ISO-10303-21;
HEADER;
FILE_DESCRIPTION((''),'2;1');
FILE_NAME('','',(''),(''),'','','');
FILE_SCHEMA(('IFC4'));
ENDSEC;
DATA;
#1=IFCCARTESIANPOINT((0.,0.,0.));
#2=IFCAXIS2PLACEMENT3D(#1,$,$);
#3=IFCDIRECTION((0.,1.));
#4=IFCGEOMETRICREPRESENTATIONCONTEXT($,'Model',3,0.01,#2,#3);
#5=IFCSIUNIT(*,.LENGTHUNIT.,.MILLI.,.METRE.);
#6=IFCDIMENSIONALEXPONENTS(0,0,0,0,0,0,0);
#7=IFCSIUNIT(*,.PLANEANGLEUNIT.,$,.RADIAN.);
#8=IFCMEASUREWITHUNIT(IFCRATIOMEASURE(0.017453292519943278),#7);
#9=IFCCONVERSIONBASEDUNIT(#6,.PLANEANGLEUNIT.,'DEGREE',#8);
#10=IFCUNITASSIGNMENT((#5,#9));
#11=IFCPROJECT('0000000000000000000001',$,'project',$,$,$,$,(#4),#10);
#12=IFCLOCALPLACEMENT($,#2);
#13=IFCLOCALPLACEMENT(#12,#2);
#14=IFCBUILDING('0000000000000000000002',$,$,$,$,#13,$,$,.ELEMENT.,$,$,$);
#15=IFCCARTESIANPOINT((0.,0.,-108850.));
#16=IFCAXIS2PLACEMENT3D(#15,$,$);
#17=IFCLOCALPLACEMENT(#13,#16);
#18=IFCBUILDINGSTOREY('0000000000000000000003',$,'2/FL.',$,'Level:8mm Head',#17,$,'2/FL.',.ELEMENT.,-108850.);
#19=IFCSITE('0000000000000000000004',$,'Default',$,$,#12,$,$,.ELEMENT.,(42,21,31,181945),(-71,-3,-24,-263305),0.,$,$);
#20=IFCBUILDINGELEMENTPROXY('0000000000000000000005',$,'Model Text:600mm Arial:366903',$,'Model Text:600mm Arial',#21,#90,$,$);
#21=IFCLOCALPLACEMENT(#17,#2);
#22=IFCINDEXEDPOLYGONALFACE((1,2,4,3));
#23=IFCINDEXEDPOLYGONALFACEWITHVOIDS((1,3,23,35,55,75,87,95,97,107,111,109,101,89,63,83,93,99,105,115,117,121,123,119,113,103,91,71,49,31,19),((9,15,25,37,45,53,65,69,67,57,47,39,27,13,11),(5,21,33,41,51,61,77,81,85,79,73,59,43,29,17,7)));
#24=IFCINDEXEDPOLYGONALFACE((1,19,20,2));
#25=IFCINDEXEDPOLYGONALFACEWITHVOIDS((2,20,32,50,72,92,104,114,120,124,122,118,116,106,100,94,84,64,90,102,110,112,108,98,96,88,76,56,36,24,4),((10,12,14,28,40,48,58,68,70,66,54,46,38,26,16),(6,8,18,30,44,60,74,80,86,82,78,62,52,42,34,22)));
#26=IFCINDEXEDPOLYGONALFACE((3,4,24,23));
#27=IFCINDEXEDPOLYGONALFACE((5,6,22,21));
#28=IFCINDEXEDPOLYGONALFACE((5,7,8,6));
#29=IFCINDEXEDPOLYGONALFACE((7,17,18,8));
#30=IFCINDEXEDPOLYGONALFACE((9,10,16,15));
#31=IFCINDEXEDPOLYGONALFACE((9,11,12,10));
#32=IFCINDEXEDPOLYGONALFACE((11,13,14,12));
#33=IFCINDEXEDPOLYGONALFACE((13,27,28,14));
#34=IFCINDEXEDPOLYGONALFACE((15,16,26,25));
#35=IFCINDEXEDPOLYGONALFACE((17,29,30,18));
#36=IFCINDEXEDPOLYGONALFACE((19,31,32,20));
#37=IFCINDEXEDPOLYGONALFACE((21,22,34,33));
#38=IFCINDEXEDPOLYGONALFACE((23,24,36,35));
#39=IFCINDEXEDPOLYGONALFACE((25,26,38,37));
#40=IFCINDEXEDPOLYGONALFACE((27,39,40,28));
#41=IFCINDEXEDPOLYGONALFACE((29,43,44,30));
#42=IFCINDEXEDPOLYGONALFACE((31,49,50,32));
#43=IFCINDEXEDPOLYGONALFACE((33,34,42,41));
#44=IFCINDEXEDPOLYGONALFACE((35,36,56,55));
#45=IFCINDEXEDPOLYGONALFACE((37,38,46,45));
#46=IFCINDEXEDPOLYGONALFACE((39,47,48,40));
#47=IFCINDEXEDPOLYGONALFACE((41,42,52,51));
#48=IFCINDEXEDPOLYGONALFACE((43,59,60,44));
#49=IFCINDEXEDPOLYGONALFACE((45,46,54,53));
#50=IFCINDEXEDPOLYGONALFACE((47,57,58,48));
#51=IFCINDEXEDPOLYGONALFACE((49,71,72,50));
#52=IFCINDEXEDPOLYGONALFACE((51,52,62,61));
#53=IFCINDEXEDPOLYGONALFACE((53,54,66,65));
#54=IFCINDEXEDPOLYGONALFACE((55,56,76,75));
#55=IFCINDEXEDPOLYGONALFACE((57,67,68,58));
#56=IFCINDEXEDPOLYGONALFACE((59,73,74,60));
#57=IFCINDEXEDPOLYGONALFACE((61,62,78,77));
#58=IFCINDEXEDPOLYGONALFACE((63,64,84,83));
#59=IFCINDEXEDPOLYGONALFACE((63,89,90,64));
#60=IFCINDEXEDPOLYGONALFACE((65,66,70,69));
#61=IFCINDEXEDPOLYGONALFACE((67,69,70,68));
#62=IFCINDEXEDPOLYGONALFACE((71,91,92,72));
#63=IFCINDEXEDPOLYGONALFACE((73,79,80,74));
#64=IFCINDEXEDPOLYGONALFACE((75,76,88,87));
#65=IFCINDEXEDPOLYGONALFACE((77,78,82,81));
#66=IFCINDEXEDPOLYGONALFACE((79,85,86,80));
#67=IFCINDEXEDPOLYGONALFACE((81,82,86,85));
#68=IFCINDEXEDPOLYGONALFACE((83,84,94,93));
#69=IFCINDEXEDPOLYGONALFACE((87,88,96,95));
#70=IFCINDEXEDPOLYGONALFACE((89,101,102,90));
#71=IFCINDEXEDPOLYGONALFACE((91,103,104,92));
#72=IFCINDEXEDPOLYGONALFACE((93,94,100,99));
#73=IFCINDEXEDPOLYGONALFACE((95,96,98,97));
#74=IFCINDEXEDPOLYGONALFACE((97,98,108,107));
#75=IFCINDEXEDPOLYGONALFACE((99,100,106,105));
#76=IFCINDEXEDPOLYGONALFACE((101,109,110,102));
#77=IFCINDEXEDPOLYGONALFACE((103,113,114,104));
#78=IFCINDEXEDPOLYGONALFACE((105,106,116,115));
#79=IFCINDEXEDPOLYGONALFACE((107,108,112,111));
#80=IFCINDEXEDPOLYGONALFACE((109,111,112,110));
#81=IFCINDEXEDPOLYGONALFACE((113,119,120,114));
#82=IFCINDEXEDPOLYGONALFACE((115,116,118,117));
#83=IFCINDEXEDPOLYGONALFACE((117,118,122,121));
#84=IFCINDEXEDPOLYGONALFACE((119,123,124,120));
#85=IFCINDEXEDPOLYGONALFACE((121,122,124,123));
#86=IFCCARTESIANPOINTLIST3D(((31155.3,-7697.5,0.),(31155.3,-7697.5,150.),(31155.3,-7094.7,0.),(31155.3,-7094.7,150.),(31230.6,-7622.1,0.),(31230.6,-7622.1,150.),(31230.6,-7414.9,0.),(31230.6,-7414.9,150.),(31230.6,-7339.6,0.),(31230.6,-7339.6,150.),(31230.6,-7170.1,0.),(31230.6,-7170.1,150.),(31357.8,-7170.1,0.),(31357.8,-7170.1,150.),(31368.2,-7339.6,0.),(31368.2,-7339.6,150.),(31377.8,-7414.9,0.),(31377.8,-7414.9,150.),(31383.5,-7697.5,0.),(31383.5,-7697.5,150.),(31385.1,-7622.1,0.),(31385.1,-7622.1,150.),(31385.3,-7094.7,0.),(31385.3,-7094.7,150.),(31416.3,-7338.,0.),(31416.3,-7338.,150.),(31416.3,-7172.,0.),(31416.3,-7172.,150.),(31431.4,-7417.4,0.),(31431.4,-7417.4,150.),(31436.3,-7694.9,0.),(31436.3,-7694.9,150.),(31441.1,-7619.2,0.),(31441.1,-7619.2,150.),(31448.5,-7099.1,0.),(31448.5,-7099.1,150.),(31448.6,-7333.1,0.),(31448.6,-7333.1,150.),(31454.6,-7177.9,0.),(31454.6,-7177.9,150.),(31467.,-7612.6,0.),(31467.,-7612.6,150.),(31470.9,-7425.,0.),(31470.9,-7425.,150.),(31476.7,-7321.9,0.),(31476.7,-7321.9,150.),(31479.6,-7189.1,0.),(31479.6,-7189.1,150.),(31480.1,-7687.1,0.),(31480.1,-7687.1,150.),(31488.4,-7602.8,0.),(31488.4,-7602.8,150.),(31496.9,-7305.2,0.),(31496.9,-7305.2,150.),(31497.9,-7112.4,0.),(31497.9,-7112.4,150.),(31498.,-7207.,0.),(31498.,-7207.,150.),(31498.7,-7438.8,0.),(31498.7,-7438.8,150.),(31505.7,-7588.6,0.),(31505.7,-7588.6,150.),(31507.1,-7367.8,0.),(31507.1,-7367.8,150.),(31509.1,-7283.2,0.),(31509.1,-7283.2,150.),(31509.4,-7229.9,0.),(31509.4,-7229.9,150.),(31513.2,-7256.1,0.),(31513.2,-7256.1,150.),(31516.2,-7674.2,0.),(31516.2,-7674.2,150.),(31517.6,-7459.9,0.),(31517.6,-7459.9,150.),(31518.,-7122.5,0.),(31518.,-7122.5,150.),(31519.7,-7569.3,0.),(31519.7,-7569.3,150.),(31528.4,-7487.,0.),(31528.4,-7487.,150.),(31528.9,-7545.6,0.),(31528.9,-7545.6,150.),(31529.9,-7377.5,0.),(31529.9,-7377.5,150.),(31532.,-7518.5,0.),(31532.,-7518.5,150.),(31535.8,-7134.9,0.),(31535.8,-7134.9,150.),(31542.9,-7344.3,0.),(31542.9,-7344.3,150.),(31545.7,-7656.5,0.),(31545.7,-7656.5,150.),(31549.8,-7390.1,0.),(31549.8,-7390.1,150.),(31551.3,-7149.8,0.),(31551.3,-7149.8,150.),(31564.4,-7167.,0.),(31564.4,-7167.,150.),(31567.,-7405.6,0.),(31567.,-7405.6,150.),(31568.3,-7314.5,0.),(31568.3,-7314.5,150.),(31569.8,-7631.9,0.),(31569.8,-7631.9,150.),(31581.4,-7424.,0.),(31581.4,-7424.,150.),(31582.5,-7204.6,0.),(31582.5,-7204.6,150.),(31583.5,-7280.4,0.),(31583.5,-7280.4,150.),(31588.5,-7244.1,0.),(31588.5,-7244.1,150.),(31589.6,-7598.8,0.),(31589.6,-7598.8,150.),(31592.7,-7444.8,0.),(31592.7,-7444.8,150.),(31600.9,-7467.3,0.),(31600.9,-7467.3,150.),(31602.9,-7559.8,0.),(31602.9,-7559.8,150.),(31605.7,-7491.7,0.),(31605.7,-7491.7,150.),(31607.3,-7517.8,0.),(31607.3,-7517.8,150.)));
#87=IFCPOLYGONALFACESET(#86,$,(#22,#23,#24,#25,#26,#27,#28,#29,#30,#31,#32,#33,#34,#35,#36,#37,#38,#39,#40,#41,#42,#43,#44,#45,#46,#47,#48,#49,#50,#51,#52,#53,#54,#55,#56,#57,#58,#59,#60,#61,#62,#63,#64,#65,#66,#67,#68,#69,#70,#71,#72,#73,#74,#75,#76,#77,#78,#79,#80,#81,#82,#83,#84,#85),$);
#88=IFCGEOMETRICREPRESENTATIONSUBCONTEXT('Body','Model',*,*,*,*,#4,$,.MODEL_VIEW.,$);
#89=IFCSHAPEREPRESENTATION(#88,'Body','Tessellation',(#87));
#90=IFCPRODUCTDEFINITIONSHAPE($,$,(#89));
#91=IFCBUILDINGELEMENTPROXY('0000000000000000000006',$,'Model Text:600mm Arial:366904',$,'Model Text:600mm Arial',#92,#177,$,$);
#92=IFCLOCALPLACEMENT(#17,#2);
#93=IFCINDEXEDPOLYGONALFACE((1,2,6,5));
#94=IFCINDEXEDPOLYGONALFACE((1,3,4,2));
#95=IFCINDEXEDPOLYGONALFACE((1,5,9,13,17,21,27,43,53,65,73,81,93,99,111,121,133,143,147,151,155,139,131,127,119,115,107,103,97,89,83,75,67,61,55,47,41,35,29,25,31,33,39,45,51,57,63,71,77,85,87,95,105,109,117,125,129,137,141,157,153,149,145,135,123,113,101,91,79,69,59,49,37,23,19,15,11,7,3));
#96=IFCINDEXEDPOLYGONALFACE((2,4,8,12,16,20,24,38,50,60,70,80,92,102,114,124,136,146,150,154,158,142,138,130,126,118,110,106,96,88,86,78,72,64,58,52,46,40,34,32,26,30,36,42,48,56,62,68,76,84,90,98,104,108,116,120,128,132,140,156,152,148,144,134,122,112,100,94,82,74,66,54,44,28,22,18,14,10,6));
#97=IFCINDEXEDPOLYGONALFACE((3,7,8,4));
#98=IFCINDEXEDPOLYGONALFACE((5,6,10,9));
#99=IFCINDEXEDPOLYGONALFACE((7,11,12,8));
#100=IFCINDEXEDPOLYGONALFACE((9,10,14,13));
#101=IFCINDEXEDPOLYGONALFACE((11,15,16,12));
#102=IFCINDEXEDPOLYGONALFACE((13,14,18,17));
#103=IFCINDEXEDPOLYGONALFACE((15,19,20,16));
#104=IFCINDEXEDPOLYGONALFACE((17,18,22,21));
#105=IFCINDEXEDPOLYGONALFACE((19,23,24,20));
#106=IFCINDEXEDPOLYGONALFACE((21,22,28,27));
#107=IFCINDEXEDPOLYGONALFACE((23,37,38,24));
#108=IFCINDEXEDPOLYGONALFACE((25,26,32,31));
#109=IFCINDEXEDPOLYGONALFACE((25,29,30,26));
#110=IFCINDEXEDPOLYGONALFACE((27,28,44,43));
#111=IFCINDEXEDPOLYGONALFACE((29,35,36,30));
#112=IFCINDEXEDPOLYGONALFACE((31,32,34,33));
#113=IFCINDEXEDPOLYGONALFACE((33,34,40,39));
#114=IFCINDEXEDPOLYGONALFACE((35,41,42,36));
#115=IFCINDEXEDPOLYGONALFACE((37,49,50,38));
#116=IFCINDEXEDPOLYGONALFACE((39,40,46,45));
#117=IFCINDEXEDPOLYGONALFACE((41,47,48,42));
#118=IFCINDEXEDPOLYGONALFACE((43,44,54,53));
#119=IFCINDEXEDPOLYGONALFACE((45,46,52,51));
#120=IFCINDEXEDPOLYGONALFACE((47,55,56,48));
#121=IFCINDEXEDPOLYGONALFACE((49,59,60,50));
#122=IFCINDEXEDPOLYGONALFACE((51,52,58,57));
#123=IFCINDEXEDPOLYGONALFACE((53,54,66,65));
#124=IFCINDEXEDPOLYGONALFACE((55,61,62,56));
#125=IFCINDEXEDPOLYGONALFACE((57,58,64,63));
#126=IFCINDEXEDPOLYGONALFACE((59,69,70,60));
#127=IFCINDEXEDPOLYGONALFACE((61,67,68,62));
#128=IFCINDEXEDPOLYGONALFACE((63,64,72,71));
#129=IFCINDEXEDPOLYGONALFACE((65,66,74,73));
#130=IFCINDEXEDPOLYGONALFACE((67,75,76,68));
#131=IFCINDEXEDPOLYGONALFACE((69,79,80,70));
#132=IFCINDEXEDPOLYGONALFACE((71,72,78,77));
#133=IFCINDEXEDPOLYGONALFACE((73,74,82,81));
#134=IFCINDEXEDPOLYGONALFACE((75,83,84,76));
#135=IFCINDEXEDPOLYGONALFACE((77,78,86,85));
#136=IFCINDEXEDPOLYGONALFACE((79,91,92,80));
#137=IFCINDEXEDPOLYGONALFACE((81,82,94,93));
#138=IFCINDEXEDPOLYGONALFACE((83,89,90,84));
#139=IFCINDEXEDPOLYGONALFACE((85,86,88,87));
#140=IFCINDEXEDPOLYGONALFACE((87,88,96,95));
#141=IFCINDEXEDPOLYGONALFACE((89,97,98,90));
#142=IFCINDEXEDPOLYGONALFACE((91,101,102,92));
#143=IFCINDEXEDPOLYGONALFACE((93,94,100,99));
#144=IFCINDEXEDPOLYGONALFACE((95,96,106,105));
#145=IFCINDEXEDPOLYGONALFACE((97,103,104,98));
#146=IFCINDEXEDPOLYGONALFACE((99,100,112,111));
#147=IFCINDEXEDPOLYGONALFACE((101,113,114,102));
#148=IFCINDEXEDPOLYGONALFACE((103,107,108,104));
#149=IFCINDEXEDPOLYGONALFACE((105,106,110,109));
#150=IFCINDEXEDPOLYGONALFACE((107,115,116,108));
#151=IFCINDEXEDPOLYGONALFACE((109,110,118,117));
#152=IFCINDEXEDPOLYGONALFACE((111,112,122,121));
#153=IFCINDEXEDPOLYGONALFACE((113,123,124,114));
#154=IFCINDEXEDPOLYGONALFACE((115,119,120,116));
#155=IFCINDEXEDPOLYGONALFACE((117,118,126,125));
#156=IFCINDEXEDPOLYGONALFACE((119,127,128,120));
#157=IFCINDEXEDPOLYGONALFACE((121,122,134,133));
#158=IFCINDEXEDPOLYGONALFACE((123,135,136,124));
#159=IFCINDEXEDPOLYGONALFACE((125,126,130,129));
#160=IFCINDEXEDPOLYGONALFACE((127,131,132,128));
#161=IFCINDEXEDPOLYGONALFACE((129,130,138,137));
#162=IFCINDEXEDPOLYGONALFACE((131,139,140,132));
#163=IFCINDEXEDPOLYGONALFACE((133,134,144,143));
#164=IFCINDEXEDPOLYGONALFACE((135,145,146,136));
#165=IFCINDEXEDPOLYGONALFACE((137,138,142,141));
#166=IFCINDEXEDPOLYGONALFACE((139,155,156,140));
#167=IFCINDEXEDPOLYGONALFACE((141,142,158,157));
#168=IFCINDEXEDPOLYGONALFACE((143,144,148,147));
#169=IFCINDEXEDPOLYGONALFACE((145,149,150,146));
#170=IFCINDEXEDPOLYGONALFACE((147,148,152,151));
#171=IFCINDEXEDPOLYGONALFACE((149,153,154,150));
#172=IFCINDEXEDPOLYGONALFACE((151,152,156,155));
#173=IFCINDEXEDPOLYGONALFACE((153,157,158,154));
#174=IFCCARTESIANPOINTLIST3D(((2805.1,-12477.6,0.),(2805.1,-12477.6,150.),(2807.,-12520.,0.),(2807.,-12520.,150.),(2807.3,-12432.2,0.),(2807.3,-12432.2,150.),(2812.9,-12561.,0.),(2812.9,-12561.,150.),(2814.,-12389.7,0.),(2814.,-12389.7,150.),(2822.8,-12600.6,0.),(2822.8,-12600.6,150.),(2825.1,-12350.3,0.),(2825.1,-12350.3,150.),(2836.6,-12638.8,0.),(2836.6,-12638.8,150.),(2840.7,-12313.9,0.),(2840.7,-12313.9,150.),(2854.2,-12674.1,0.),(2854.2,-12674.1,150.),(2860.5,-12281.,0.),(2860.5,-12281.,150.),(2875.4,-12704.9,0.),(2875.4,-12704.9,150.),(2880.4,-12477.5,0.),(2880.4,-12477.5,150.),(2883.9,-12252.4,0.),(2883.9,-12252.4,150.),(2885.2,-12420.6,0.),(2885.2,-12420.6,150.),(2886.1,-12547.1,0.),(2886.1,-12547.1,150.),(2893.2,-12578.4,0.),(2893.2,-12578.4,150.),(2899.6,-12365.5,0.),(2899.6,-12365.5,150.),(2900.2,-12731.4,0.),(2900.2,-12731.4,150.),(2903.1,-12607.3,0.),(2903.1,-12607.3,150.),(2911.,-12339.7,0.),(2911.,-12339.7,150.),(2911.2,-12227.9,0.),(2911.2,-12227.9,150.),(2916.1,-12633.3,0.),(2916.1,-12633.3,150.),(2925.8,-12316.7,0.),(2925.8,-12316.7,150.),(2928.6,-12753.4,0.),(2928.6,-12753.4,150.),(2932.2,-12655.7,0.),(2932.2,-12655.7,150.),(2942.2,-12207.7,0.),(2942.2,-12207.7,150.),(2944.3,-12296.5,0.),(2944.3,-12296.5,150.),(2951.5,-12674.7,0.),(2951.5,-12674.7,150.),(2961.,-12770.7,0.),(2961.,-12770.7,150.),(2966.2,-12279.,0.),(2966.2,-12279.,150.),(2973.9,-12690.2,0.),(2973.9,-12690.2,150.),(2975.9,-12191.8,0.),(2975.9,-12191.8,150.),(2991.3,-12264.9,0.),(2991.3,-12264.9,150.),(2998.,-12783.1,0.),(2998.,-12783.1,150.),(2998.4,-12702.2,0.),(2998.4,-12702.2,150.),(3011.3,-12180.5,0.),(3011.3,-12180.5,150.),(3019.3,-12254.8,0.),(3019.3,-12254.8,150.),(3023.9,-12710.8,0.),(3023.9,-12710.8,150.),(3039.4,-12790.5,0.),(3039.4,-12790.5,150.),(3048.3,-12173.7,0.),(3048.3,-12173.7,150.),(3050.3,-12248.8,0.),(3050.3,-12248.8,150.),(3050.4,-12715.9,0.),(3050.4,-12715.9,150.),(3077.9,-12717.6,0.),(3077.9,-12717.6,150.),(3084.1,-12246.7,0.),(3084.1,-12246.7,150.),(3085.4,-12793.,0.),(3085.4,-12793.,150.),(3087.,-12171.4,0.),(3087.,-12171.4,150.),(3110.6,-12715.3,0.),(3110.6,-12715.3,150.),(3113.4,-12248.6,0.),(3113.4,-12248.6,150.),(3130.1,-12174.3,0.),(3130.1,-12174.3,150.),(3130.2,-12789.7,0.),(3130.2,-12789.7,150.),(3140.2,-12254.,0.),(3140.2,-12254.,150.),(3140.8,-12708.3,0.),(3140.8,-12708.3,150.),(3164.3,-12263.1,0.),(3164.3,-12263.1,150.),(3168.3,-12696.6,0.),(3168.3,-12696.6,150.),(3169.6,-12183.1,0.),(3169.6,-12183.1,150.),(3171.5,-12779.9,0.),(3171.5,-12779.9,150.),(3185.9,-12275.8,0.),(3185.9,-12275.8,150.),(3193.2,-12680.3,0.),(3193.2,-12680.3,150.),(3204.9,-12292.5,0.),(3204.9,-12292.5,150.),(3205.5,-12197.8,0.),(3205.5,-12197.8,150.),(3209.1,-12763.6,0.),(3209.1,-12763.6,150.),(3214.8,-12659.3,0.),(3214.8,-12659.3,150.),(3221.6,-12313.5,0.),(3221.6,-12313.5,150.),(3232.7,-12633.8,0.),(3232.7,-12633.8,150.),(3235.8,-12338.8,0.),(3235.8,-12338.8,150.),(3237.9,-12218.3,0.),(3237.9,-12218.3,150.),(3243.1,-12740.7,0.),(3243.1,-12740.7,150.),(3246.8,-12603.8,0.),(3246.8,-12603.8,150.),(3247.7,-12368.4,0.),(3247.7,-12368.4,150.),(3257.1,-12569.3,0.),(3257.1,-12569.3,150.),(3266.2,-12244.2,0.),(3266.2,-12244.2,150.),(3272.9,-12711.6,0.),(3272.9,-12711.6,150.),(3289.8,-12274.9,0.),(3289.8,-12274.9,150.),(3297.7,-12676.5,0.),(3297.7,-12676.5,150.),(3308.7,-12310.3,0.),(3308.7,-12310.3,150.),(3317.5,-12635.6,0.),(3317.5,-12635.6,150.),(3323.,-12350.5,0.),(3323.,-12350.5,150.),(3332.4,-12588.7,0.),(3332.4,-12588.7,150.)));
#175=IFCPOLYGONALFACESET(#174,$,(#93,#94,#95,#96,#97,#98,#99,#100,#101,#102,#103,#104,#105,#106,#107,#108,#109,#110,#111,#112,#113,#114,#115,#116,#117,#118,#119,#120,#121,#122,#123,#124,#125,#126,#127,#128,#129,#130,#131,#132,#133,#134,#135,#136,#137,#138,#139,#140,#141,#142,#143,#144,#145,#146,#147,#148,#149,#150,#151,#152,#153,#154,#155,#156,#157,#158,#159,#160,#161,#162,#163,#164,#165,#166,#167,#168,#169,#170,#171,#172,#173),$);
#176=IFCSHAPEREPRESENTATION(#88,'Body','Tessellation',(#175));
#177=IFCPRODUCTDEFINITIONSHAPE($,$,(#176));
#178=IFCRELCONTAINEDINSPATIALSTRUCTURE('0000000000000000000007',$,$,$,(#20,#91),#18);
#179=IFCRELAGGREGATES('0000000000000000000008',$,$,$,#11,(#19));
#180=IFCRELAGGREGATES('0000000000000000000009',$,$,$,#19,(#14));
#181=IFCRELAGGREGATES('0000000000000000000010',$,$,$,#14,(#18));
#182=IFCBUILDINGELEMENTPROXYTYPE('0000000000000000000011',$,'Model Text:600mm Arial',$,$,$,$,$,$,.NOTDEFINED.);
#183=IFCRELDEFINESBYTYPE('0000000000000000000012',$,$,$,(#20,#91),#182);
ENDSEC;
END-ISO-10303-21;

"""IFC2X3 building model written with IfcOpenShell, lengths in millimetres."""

from ifc_helpers import new_model, entity, si_unit, converted_unit, direction, frame, origin, place, context, subcontext, project, spatial, polyline, outline, extrude, type_object, element, save


model = new_model("IFC2X3")

# Units and contexts
model_context = context("Model", 3, precision=0.01, world=origin(), true_north=direction((0.0, 1.0)))
body_context = subcontext(model_context, "Body", "Model", "MODEL_VIEW")
ifc_project = project(units=[si_unit("LENGTHUNIT", "METRE", prefix="MILLI"), converted_unit("PLANEANGLEUNIT", "DEGREE", entity("IfcRatioMeasure", 0.017453292519943278), si_unit("PLANEANGLEUNIT", "RADIAN"), dimensions=[0, 0, 0, 0, 0, 0, 0])], contexts=[model_context])

# Site, building, storey
site_placement = place(None, origin())
site = spatial("IfcSite", under=ifc_project, at=site_placement, Name="Default", CompositionType="ELEMENT", RefLatitude=(42, 21, 31, 181945), RefLongitude=(-71, -3, -24, -263305), RefElevation=0.0)
building_placement = place(site_placement, origin())
building = spatial("IfcBuilding", under=site, at=building_placement, CompositionType="ELEMENT")
storey_placement = place(building_placement, frame((0.0, 0.0, -108850.0)))
storey = spatial("IfcBuildingStorey", under=building, at=storey_placement, Name="2/FL.", ObjectType="Level:8mm Head", LongName="2/FL.", CompositionType="ELEMENT", Elevation=-108850.0)

# Building element proxies
building_element_proxy_type = type_object("IfcBuildingElementProxyType", Name="Model Text:600mm Arial", PredefinedType="NOTDEFINED")
proxy_1_placement = place(storey_placement, origin())
element("IfcBuildingElementProxy", 1, at=proxy_1_placement, inside=storey, type_object=building_element_proxy_type, Name="Model Text:600mm Arial:366903", ObjectType="Model Text:600mm Arial", context=body_context, shape_type="SweptSolid", body=[
    extrude(outline(polyline([(-359.0, -305.6), (-130.8, -305.6), (-78.0, -303.0), (-34.2, -295.2), (1.9, -282.4), (31.4, -264.6), (55.5, -240.1), (75.3, -206.9), (88.6, -167.9), (93.0, -125.9), (91.4, -99.8), (86.5, -75.5), (78.4, -52.9), (67.1, -32.2), (52.7, -13.8), (35.5, 1.7), (15.6, 14.3), (-7.2, 24.0), (28.6, 47.5), (54.0, 77.4), (69.1, 111.5), (74.2, 147.8), (68.2, 187.2), (50.1, 224.9), (37.0, 242.1), (21.5, 256.9), (3.7, 269.4), (-16.4, 279.4), (-65.8, 292.7), (-129.0, 297.2), (-359.0, 297.2), (-359.0, -305.6)]), holes=[polyline([(-283.7, 52.3), (-283.7, 221.8), (-156.5, 221.8), (-98.0, 219.8), (-59.7, 213.9), (-34.7, 202.7), (-16.3, 184.9), (-4.9, 162.0), (-1.1, 135.7), (-5.2, 108.7), (-17.4, 86.7), (-37.6, 69.9), (-65.7, 58.8), (-98.0, 53.9), (-146.1, 52.3), (-283.7, 52.3)]), polyline([(-283.7, -230.2), (-283.7, -23.1), (-136.5, -23.1), (-82.9, -25.6), (-43.4, -33.1), (-15.6, -46.9), (3.3, -68.1), (14.1, -95.2), (17.7, -126.6), (14.6, -153.8), (5.4, -177.4), (-8.6, -196.7), (-25.9, -210.9), (-47.3, -220.8), (-73.2, -227.3), (-129.2, -230.2), (-283.7, -230.2)])]), frame((31514.3, -7391.9, 0.0)), (0.0, 0.0, 1.0), 150.0),
])
proxy_2_placement = place(storey_placement, origin())
element("IfcBuildingElementProxy", 2, at=proxy_2_placement, inside=storey, type_object=building_element_proxy_type, Name="Model Text:600mm Arial:366904", ObjectType="Model Text:600mm Arial", context=body_context, shape_type="SweptSolid", body=[
    extrude(outline(polyline([(25.5, -224.6), (22.6, -302.4), (71.8, -301.5), (116.7, -294.1), (157.3, -280.3), (193.7, -260.1), (225.4, -234.1), (251.8, -202.7), (273.0, -165.9), (288.9, -123.9), (299.7, -79.2), (304.4, -37.3), (303.1, 1.6), (295.7, 37.7), (282.8, 71.2), (264.5, 102.5), (241.0, 131.6), (212.2, 158.5), (179.5, 182.7), (144.3, 203.4), (106.8, 220.8), (66.7, 234.8), (22.6, 245.6), (-20.0, 251.3), (-61.0, 251.9), (-100.4, 247.4), (-137.5, 237.8), (-171.7, 223.5), (-202.9, 204.4), (-231.1, 180.4), (-256.0, 152.7), (-276.9, 122.0), (-294.0, 88.5), (-307.2, 52.0), (-316.7, 9.9), (-319.6, -30.5), (-315.8, -69.1), (-305.3, -106.0), (-288.6, -140.4), (-266.0, -171.8), (-237.5, -200.1), (-203.0, -225.3), (-164.3, -158.2), (-189.3, -138.4), (-209.5, -117.5), (-224.9, -95.6), (-235.4, -72.5), (-241.5, -48.3), (-243.3, -22.5), (-240.8, 4.7), (-234.2, 33.3), (-222.6, 65.2), (-208.0, 93.1), (-190.3, 117.0), (-169.7, 137.1), (-146.6, 153.1), (-122.0, 165.0), (-95.7, 172.7), (-67.7, 176.2), (-10.8, 174.3), (45.1, 162.6), (110.2, 137.3), (138.1, 121.6), (163.0, 103.8), (184.2, 84.0), (201.1, 62.1), (213.8, 38.2), (222.2, 12.3), (226.7, -14.6), (227.7, -41.5), (225.1, -68.4), (218.9, -95.2), (207.3, -125.9), (191.9, -152.8), (172.9, -175.8), (150.1, -195.0), (123.8, -209.8), (94.3, -219.7), (61.5, -224.6), (25.5, -224.6)])), frame((3049.1, -12480.7, 0.0), z_axis=(0.0, 0.0, -1.0), x_axis=(-0.285544, -0.958366, 0.0)), (0.0, 0.0, -1.0), 150.0),
])

save(model, "model.ifc")
